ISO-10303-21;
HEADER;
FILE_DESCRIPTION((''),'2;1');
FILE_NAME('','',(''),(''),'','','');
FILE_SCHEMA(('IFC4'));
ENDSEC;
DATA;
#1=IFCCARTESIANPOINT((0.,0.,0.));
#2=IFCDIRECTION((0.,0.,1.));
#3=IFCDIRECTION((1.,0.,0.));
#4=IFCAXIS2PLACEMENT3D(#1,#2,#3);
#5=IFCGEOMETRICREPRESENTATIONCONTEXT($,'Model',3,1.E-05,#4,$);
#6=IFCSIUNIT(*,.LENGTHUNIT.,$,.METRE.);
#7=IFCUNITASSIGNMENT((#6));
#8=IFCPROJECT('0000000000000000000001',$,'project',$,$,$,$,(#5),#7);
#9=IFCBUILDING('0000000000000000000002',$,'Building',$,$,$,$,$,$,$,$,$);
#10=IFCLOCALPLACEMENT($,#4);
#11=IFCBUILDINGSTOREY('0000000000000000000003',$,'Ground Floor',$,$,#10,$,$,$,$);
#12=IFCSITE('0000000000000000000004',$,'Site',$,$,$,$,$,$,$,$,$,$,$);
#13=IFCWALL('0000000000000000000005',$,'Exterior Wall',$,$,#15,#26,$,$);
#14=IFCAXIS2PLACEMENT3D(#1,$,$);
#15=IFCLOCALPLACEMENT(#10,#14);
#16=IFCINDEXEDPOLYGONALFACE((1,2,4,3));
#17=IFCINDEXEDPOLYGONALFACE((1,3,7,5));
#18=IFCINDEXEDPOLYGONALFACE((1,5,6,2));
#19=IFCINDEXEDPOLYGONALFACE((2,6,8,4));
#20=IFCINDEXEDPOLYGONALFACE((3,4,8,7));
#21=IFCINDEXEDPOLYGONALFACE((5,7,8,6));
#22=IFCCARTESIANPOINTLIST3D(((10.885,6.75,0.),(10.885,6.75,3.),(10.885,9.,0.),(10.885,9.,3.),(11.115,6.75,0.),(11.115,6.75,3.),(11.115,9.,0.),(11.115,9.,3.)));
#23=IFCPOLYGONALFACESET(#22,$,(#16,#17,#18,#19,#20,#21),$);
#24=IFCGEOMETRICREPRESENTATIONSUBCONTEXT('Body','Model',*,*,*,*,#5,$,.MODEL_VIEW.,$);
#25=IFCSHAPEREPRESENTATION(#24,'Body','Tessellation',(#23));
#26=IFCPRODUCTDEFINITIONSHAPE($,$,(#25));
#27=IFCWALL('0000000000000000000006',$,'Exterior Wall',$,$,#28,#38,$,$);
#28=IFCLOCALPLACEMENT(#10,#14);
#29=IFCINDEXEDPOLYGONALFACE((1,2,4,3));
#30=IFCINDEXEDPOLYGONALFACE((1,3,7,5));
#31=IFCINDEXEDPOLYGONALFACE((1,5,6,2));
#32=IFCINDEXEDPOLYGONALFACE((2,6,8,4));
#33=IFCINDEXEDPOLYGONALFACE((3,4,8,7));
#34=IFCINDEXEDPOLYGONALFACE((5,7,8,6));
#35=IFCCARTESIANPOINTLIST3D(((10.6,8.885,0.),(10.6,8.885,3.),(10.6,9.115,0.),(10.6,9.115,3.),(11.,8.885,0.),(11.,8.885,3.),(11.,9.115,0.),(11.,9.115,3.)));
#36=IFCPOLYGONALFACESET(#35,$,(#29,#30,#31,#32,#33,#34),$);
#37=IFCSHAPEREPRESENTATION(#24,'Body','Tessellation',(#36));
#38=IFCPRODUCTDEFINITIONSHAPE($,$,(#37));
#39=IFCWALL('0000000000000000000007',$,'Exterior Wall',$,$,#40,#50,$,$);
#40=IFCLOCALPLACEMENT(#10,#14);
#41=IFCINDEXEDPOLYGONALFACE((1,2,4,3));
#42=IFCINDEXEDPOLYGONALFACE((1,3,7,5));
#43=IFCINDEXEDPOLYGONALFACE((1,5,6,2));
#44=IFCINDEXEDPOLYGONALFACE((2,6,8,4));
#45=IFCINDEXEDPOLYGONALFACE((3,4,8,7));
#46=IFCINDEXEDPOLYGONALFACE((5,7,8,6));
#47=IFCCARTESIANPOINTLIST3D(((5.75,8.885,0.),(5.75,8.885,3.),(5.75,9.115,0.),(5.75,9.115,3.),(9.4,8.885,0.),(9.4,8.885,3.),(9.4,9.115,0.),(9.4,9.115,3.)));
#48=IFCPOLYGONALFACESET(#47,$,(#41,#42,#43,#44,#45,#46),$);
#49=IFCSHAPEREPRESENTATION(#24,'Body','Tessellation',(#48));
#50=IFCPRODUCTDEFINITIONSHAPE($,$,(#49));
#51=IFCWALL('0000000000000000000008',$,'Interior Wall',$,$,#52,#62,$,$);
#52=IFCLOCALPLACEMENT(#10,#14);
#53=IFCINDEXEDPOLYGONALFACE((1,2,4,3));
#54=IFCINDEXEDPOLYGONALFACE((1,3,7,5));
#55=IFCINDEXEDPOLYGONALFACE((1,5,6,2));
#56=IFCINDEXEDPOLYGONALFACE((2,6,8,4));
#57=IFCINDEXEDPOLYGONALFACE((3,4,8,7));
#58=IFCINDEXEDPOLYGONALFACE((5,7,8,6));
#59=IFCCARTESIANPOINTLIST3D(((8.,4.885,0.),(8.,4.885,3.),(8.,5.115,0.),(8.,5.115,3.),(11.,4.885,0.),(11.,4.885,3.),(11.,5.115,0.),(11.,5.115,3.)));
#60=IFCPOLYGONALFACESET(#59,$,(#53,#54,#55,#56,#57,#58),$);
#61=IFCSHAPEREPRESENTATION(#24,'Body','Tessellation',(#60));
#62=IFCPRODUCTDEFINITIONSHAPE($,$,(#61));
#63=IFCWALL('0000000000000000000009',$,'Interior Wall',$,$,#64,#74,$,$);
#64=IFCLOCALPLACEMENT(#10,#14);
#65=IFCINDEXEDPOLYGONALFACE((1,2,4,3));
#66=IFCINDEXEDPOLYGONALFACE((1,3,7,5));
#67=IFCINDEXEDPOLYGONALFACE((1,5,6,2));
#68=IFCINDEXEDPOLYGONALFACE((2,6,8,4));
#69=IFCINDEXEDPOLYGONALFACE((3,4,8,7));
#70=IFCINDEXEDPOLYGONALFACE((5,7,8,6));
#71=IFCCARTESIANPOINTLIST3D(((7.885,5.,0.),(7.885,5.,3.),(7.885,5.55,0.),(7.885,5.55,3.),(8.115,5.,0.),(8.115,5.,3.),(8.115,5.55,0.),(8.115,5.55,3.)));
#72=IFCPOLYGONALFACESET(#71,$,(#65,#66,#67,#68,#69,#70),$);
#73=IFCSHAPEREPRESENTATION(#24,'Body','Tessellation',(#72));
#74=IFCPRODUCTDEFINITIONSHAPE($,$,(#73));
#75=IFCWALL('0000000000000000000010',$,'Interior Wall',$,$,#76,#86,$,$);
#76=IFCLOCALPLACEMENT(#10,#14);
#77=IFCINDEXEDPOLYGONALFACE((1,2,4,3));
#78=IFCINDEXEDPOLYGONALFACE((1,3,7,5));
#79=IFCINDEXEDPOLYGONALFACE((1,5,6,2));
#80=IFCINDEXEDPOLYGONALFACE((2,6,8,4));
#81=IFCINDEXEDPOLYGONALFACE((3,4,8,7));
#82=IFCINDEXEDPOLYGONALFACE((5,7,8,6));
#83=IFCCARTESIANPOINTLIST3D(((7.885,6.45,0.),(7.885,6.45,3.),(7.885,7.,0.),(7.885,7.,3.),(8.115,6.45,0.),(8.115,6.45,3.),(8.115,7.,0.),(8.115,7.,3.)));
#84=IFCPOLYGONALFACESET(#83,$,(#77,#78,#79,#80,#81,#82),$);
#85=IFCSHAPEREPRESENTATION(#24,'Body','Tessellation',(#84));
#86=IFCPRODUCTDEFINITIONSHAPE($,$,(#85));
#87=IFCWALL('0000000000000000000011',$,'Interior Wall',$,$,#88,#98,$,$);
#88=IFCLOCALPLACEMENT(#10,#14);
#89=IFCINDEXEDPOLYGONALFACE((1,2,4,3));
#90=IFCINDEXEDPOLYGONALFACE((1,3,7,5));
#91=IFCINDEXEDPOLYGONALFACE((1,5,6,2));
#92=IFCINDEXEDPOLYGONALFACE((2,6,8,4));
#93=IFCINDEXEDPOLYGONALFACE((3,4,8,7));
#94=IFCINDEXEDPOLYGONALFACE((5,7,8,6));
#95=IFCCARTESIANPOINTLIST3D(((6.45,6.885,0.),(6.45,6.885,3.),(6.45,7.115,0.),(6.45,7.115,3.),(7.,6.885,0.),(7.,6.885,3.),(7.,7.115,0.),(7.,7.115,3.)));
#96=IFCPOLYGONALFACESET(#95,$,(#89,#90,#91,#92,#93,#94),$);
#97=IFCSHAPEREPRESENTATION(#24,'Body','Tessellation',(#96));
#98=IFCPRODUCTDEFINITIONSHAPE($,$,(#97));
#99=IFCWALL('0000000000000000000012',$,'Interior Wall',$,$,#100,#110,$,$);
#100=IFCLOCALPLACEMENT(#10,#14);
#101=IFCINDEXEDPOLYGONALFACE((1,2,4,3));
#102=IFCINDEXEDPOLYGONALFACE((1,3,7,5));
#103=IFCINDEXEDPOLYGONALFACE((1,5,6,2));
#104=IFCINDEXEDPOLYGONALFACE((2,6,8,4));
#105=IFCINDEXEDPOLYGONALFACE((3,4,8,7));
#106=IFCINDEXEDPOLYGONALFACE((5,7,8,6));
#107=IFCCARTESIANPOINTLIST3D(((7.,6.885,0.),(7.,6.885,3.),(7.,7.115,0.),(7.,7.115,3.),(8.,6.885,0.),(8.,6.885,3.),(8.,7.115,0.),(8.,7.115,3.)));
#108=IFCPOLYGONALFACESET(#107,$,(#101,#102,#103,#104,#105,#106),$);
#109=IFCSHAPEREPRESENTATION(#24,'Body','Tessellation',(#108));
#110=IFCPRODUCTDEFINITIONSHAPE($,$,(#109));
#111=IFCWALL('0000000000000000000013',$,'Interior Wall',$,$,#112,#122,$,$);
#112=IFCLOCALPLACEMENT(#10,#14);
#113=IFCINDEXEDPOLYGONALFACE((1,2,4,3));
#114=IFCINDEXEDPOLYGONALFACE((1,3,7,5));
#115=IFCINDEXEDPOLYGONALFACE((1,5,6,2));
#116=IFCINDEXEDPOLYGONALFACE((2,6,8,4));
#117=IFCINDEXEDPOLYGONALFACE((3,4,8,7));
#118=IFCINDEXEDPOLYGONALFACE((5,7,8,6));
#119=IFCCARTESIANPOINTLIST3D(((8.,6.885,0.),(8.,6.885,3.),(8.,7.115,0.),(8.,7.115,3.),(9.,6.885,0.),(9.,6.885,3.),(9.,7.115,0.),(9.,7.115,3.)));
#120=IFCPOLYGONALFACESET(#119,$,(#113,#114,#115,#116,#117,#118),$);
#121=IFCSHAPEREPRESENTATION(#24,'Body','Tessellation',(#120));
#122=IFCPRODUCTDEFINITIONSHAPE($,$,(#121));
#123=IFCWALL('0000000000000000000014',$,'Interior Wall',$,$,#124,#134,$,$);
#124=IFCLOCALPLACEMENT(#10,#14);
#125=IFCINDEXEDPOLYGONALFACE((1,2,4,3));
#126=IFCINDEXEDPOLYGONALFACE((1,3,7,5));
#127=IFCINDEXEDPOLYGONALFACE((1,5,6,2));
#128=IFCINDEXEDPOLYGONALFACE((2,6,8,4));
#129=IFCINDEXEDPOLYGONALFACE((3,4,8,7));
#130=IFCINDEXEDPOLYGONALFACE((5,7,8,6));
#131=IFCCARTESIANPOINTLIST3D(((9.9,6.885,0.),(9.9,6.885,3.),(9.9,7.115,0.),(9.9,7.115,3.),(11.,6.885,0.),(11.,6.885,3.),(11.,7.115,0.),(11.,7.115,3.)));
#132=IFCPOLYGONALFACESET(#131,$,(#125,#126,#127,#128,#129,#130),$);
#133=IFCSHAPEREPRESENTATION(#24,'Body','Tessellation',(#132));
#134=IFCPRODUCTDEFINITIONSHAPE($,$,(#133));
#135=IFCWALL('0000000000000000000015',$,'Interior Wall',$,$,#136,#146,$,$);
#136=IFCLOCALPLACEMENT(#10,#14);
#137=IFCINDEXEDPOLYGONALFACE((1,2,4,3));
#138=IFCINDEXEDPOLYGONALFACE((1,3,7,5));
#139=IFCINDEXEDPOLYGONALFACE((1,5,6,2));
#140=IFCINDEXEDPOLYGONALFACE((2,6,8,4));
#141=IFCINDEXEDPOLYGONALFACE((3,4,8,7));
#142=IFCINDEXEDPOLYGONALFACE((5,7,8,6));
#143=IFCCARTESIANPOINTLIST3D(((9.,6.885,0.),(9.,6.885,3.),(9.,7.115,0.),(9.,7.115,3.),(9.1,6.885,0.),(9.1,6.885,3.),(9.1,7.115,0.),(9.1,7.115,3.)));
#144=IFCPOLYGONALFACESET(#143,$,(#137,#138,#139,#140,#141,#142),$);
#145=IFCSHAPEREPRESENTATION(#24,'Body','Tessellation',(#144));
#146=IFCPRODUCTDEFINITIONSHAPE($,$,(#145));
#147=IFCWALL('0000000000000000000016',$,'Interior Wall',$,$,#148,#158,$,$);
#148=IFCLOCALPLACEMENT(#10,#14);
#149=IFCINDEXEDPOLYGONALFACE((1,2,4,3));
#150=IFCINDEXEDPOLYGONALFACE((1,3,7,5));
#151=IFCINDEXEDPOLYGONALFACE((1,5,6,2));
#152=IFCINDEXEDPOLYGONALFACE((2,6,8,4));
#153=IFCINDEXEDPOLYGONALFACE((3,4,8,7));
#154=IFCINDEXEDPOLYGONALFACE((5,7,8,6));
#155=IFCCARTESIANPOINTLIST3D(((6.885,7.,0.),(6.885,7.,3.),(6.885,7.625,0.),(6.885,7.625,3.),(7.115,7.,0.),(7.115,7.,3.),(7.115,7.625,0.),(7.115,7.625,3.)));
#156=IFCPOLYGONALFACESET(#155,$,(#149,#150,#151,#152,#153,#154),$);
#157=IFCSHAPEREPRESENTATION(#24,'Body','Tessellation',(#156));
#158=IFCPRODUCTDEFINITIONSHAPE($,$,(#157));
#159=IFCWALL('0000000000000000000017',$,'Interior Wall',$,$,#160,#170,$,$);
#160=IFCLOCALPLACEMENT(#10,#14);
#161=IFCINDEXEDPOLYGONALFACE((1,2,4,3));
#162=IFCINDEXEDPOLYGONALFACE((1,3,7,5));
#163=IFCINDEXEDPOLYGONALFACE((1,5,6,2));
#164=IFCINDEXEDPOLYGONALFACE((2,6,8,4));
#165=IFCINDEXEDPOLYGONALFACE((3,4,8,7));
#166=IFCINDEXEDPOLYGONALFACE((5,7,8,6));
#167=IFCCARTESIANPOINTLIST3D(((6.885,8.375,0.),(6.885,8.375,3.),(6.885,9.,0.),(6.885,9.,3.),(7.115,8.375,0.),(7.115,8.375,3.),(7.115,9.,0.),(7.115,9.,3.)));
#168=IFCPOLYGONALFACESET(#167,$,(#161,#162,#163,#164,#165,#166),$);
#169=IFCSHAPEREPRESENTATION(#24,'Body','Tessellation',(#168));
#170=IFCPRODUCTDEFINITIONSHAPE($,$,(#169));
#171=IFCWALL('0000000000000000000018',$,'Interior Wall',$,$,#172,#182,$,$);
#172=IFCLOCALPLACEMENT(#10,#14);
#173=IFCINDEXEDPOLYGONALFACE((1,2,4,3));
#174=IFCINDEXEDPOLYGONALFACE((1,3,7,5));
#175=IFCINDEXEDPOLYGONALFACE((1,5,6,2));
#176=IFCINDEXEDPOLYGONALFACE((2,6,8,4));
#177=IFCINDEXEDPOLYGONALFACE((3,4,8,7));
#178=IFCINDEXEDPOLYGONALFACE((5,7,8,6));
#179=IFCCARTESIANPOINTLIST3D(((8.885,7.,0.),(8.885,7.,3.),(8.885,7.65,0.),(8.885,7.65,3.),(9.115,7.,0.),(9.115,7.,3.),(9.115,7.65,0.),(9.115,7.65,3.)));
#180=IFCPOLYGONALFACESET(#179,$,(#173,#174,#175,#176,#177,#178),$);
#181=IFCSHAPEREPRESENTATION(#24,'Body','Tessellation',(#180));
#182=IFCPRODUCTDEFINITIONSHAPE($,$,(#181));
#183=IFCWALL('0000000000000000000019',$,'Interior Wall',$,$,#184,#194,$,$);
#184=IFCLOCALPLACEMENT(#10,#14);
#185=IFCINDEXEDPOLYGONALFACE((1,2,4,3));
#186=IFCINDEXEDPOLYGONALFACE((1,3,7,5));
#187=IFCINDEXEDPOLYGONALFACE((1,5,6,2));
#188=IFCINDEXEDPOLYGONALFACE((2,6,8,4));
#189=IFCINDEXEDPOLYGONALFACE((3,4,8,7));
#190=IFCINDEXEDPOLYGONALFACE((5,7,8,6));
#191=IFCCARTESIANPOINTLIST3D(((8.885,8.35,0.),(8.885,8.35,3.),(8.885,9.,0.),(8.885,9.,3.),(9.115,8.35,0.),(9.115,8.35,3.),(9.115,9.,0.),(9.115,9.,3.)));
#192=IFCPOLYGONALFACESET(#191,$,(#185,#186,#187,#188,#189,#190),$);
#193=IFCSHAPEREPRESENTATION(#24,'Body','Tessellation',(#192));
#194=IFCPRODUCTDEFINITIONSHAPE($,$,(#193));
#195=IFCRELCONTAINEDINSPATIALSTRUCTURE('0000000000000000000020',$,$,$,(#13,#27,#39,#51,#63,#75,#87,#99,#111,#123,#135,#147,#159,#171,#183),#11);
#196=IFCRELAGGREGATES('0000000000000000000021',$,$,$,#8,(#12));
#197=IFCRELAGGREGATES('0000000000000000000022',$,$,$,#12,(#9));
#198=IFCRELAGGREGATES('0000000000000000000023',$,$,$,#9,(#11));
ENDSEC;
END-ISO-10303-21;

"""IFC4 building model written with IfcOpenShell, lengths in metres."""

from ifc_helpers import new_model, si_unit, frame, origin_with_axes, place, context, subcontext, project, spatial, indexed_curve, outline, extrude, element, save


model = new_model("IFC4")

# Units and contexts
model_context = context("Model", 3, precision=1e-05, world=origin_with_axes())
body_context = subcontext(model_context, "Body", "Model", "MODEL_VIEW")
ifc_project = project(units=[si_unit("LENGTHUNIT", "METRE")], contexts=[model_context])

# Site, building, storey
site = spatial("IfcSite", under=ifc_project, Name="Site")
building = spatial("IfcBuilding", under=site, Name="Building")
storey_placement = place(None, origin_with_axes())
storey = spatial("IfcBuildingStorey", under=building, at=storey_placement, Name="Ground Floor")

# Walls
wall_1_placement = place(storey_placement, frame((11.0, 6.75, 0.0), z_axis=(0.0, 0.0, 1.0), x_axis=(0.0, 1.0, 0.0)))
element("IfcWall", 1, at=wall_1_placement, inside=storey, Name="Exterior Wall", context=body_context, shape_type="SweptSolid", body=[
    extrude(outline(indexed_curve([(0.0, 0.0), (0.0, 0.23), (2.25, 0.23), (2.25, 0.0), (0.0, 0.0)], self_intersect=False)), frame((0.0, -0.115, 0.0), z_axis=(0.0, 0.0, 1.0), x_axis=(1.0, 0.0, 0.0)), (0.0, 0.0, 1.0), 3.0),
])
wall_2_placement = place(storey_placement, frame((11.0, 9.0, 0.0), z_axis=(0.0, 0.0, 1.0), x_axis=(-1.0, 0.0, 0.0)))
element("IfcWall", 2, at=wall_2_placement, inside=storey, Name="Exterior Wall", context=body_context, shape_type="SweptSolid", body=[
    extrude(outline(indexed_curve([(0.0, 0.0), (0.0, 0.23), (0.4, 0.23), (0.4, 0.0), (0.0, 0.0)], self_intersect=False)), frame((0.0, -0.115, 0.0), z_axis=(0.0, 0.0, 1.0), x_axis=(1.0, 0.0, 0.0)), (0.0, 0.0, 1.0), 3.0),
])
wall_3_placement = place(storey_placement, frame((9.4, 9.0, 0.0), z_axis=(0.0, 0.0, 1.0), x_axis=(-1.0, 0.0, 0.0)))
element("IfcWall", 3, at=wall_3_placement, inside=storey, Name="Exterior Wall", context=body_context, shape_type="SweptSolid", body=[
    extrude(outline(indexed_curve([(0.0, 0.0), (0.0, 0.23), (3.65, 0.23), (3.65, 0.0), (0.0, 0.0)], self_intersect=False)), frame((0.0, -0.115, 0.0), z_axis=(0.0, 0.0, 1.0), x_axis=(1.0, 0.0, 0.0)), (0.0, 0.0, 1.0), 3.0),
])
wall_4_placement = place(storey_placement, frame((11.0, 5.0, 0.0), z_axis=(0.0, 0.0, 1.0), x_axis=(-1.0, 0.0, 0.0)))
element("IfcWall", 4, at=wall_4_placement, inside=storey, Name="Interior Wall", context=body_context, shape_type="SweptSolid", body=[
    extrude(outline(indexed_curve([(0.0, 0.0), (0.0, 0.23), (3.0, 0.23), (3.0, 0.0), (0.0, 0.0)], self_intersect=False)), frame((0.0, -0.115, 0.0), z_axis=(0.0, 0.0, 1.0), x_axis=(1.0, 0.0, 0.0)), (0.0, 0.0, 1.0), 3.0),
])
for number, where, z_axis, x_axis, name in (
    (5, (8.0, 5.0, 0.0), (0.0, 0.0, 1.0), (0.0, 1.0, 0.0), "Interior Wall"),
    (6, (8.0, 6.45, 0.0), (0.0, 0.0, 1.0), (0.0, 1.0, 0.0), "Interior Wall"),
    (7, (7.0, 7.0, 0.0), (0.0, 0.0, 1.0), (-1.0, 0.0, 0.0), "Interior Wall"),
):
    element("IfcWall", number, at=place(storey_placement, frame(where, z_axis=z_axis, x_axis=x_axis)), inside=storey, Name=name, context=body_context, shape_type="SweptSolid", body=[
        extrude(outline(indexed_curve([(0.0, 0.0), (0.0, 0.23), (0.55, 0.23), (0.55, 0.0), (0.0, 0.0)], self_intersect=False)), frame((0.0, -0.115, 0.0), z_axis=(0.0, 0.0, 1.0), x_axis=(1.0, 0.0, 0.0)), (0.0, 0.0, 1.0), 3.0),
    ])
for number, where, z_axis, x_axis, name in (
    (8, (8.0, 7.0, 0.0), (0.0, 0.0, 1.0), (-1.0, 0.0, 0.0), "Interior Wall"),
    (9, (9.0, 7.0, 0.0), (0.0, 0.0, 1.0), (-1.0, 0.0, 0.0), "Interior Wall"),
):
    element("IfcWall", number, at=place(storey_placement, frame(where, z_axis=z_axis, x_axis=x_axis)), inside=storey, Name=name, context=body_context, shape_type="SweptSolid", body=[
        extrude(outline(indexed_curve([(0.0, 0.0), (0.0, 0.23), (1.0, 0.23), (1.0, 0.0), (0.0, 0.0)], self_intersect=False)), frame((0.0, -0.115, 0.0), z_axis=(0.0, 0.0, 1.0), x_axis=(1.0, 0.0, 0.0)), (0.0, 0.0, 1.0), 3.0),
    ])
wall_5_placement = place(storey_placement, frame((11.0, 7.0, 0.0), z_axis=(0.0, 0.0, 1.0), x_axis=(-1.0, 0.0, 0.0)))
element("IfcWall", 10, at=wall_5_placement, inside=storey, Name="Interior Wall", context=body_context, shape_type="SweptSolid", body=[
    extrude(outline(indexed_curve([(0.0, 0.0), (0.0, 0.23), (1.1, 0.23), (1.1, 0.0), (0.0, 0.0)], self_intersect=False)), frame((0.0, -0.115, 0.0), z_axis=(0.0, 0.0, 1.0), x_axis=(1.0, 0.0, 0.0)), (0.0, 0.0, 1.0), 3.0),
])
wall_6_placement = place(storey_placement, frame((9.1, 7.0, 0.0), z_axis=(0.0, 0.0, 1.0), x_axis=(-1.0, 0.0, 0.0)))
element("IfcWall", 11, at=wall_6_placement, inside=storey, Name="Interior Wall", context=body_context, shape_type="SweptSolid", body=[
    extrude(outline(indexed_curve([(0.0, 0.0), (0.0, 0.23), (0.1, 0.23), (0.1, 0.0), (0.0, 0.0)], self_intersect=False)), frame((0.0, -0.115, 0.0), z_axis=(0.0, 0.0, 1.0), x_axis=(1.0, 0.0, 0.0)), (0.0, 0.0, 1.0), 3.0),
])
for number, where, z_axis, x_axis, name in (
    (12, (7.0, 7.0, 0.0), (0.0, 0.0, 1.0), (0.0, 1.0, 0.0), "Interior Wall"),
    (13, (7.0, 8.375, 0.0), (0.0, 0.0, 1.0), (0.0, 1.0, 0.0), "Interior Wall"),
):
    element("IfcWall", number, at=place(storey_placement, frame(where, z_axis=z_axis, x_axis=x_axis)), inside=storey, Name=name, context=body_context, shape_type="SweptSolid", body=[
        extrude(outline(indexed_curve([(0.0, 0.0), (0.0, 0.23), (0.625, 0.23), (0.625, 0.0), (0.0, 0.0)], self_intersect=False)), frame((0.0, -0.115, 0.0), z_axis=(0.0, 0.0, 1.0), x_axis=(1.0, 0.0, 0.0)), (0.0, 0.0, 1.0), 3.0),
    ])
for number, where, z_axis, x_axis, name in (
    (14, (9.0, 7.0, 0.0), (0.0, 0.0, 1.0), (0.0, 1.0, 0.0), "Interior Wall"),
    (15, (9.0, 8.35, 0.0), (0.0, 0.0, 1.0), (0.0, 1.0, 0.0), "Interior Wall"),
):
    element("IfcWall", number, at=place(storey_placement, frame(where, z_axis=z_axis, x_axis=x_axis)), inside=storey, Name=name, context=body_context, shape_type="SweptSolid", body=[
        extrude(outline(indexed_curve([(0.0, 0.0), (0.0, 0.23), (0.65, 0.23), (0.65, 0.0), (0.0, 0.0)], self_intersect=False)), frame((0.0, -0.115, 0.0), z_axis=(0.0, 0.0, 1.0), x_axis=(1.0, 0.0, 0.0)), (0.0, 0.0, 1.0), 3.0),
    ])

save(model, "model.ifc")
